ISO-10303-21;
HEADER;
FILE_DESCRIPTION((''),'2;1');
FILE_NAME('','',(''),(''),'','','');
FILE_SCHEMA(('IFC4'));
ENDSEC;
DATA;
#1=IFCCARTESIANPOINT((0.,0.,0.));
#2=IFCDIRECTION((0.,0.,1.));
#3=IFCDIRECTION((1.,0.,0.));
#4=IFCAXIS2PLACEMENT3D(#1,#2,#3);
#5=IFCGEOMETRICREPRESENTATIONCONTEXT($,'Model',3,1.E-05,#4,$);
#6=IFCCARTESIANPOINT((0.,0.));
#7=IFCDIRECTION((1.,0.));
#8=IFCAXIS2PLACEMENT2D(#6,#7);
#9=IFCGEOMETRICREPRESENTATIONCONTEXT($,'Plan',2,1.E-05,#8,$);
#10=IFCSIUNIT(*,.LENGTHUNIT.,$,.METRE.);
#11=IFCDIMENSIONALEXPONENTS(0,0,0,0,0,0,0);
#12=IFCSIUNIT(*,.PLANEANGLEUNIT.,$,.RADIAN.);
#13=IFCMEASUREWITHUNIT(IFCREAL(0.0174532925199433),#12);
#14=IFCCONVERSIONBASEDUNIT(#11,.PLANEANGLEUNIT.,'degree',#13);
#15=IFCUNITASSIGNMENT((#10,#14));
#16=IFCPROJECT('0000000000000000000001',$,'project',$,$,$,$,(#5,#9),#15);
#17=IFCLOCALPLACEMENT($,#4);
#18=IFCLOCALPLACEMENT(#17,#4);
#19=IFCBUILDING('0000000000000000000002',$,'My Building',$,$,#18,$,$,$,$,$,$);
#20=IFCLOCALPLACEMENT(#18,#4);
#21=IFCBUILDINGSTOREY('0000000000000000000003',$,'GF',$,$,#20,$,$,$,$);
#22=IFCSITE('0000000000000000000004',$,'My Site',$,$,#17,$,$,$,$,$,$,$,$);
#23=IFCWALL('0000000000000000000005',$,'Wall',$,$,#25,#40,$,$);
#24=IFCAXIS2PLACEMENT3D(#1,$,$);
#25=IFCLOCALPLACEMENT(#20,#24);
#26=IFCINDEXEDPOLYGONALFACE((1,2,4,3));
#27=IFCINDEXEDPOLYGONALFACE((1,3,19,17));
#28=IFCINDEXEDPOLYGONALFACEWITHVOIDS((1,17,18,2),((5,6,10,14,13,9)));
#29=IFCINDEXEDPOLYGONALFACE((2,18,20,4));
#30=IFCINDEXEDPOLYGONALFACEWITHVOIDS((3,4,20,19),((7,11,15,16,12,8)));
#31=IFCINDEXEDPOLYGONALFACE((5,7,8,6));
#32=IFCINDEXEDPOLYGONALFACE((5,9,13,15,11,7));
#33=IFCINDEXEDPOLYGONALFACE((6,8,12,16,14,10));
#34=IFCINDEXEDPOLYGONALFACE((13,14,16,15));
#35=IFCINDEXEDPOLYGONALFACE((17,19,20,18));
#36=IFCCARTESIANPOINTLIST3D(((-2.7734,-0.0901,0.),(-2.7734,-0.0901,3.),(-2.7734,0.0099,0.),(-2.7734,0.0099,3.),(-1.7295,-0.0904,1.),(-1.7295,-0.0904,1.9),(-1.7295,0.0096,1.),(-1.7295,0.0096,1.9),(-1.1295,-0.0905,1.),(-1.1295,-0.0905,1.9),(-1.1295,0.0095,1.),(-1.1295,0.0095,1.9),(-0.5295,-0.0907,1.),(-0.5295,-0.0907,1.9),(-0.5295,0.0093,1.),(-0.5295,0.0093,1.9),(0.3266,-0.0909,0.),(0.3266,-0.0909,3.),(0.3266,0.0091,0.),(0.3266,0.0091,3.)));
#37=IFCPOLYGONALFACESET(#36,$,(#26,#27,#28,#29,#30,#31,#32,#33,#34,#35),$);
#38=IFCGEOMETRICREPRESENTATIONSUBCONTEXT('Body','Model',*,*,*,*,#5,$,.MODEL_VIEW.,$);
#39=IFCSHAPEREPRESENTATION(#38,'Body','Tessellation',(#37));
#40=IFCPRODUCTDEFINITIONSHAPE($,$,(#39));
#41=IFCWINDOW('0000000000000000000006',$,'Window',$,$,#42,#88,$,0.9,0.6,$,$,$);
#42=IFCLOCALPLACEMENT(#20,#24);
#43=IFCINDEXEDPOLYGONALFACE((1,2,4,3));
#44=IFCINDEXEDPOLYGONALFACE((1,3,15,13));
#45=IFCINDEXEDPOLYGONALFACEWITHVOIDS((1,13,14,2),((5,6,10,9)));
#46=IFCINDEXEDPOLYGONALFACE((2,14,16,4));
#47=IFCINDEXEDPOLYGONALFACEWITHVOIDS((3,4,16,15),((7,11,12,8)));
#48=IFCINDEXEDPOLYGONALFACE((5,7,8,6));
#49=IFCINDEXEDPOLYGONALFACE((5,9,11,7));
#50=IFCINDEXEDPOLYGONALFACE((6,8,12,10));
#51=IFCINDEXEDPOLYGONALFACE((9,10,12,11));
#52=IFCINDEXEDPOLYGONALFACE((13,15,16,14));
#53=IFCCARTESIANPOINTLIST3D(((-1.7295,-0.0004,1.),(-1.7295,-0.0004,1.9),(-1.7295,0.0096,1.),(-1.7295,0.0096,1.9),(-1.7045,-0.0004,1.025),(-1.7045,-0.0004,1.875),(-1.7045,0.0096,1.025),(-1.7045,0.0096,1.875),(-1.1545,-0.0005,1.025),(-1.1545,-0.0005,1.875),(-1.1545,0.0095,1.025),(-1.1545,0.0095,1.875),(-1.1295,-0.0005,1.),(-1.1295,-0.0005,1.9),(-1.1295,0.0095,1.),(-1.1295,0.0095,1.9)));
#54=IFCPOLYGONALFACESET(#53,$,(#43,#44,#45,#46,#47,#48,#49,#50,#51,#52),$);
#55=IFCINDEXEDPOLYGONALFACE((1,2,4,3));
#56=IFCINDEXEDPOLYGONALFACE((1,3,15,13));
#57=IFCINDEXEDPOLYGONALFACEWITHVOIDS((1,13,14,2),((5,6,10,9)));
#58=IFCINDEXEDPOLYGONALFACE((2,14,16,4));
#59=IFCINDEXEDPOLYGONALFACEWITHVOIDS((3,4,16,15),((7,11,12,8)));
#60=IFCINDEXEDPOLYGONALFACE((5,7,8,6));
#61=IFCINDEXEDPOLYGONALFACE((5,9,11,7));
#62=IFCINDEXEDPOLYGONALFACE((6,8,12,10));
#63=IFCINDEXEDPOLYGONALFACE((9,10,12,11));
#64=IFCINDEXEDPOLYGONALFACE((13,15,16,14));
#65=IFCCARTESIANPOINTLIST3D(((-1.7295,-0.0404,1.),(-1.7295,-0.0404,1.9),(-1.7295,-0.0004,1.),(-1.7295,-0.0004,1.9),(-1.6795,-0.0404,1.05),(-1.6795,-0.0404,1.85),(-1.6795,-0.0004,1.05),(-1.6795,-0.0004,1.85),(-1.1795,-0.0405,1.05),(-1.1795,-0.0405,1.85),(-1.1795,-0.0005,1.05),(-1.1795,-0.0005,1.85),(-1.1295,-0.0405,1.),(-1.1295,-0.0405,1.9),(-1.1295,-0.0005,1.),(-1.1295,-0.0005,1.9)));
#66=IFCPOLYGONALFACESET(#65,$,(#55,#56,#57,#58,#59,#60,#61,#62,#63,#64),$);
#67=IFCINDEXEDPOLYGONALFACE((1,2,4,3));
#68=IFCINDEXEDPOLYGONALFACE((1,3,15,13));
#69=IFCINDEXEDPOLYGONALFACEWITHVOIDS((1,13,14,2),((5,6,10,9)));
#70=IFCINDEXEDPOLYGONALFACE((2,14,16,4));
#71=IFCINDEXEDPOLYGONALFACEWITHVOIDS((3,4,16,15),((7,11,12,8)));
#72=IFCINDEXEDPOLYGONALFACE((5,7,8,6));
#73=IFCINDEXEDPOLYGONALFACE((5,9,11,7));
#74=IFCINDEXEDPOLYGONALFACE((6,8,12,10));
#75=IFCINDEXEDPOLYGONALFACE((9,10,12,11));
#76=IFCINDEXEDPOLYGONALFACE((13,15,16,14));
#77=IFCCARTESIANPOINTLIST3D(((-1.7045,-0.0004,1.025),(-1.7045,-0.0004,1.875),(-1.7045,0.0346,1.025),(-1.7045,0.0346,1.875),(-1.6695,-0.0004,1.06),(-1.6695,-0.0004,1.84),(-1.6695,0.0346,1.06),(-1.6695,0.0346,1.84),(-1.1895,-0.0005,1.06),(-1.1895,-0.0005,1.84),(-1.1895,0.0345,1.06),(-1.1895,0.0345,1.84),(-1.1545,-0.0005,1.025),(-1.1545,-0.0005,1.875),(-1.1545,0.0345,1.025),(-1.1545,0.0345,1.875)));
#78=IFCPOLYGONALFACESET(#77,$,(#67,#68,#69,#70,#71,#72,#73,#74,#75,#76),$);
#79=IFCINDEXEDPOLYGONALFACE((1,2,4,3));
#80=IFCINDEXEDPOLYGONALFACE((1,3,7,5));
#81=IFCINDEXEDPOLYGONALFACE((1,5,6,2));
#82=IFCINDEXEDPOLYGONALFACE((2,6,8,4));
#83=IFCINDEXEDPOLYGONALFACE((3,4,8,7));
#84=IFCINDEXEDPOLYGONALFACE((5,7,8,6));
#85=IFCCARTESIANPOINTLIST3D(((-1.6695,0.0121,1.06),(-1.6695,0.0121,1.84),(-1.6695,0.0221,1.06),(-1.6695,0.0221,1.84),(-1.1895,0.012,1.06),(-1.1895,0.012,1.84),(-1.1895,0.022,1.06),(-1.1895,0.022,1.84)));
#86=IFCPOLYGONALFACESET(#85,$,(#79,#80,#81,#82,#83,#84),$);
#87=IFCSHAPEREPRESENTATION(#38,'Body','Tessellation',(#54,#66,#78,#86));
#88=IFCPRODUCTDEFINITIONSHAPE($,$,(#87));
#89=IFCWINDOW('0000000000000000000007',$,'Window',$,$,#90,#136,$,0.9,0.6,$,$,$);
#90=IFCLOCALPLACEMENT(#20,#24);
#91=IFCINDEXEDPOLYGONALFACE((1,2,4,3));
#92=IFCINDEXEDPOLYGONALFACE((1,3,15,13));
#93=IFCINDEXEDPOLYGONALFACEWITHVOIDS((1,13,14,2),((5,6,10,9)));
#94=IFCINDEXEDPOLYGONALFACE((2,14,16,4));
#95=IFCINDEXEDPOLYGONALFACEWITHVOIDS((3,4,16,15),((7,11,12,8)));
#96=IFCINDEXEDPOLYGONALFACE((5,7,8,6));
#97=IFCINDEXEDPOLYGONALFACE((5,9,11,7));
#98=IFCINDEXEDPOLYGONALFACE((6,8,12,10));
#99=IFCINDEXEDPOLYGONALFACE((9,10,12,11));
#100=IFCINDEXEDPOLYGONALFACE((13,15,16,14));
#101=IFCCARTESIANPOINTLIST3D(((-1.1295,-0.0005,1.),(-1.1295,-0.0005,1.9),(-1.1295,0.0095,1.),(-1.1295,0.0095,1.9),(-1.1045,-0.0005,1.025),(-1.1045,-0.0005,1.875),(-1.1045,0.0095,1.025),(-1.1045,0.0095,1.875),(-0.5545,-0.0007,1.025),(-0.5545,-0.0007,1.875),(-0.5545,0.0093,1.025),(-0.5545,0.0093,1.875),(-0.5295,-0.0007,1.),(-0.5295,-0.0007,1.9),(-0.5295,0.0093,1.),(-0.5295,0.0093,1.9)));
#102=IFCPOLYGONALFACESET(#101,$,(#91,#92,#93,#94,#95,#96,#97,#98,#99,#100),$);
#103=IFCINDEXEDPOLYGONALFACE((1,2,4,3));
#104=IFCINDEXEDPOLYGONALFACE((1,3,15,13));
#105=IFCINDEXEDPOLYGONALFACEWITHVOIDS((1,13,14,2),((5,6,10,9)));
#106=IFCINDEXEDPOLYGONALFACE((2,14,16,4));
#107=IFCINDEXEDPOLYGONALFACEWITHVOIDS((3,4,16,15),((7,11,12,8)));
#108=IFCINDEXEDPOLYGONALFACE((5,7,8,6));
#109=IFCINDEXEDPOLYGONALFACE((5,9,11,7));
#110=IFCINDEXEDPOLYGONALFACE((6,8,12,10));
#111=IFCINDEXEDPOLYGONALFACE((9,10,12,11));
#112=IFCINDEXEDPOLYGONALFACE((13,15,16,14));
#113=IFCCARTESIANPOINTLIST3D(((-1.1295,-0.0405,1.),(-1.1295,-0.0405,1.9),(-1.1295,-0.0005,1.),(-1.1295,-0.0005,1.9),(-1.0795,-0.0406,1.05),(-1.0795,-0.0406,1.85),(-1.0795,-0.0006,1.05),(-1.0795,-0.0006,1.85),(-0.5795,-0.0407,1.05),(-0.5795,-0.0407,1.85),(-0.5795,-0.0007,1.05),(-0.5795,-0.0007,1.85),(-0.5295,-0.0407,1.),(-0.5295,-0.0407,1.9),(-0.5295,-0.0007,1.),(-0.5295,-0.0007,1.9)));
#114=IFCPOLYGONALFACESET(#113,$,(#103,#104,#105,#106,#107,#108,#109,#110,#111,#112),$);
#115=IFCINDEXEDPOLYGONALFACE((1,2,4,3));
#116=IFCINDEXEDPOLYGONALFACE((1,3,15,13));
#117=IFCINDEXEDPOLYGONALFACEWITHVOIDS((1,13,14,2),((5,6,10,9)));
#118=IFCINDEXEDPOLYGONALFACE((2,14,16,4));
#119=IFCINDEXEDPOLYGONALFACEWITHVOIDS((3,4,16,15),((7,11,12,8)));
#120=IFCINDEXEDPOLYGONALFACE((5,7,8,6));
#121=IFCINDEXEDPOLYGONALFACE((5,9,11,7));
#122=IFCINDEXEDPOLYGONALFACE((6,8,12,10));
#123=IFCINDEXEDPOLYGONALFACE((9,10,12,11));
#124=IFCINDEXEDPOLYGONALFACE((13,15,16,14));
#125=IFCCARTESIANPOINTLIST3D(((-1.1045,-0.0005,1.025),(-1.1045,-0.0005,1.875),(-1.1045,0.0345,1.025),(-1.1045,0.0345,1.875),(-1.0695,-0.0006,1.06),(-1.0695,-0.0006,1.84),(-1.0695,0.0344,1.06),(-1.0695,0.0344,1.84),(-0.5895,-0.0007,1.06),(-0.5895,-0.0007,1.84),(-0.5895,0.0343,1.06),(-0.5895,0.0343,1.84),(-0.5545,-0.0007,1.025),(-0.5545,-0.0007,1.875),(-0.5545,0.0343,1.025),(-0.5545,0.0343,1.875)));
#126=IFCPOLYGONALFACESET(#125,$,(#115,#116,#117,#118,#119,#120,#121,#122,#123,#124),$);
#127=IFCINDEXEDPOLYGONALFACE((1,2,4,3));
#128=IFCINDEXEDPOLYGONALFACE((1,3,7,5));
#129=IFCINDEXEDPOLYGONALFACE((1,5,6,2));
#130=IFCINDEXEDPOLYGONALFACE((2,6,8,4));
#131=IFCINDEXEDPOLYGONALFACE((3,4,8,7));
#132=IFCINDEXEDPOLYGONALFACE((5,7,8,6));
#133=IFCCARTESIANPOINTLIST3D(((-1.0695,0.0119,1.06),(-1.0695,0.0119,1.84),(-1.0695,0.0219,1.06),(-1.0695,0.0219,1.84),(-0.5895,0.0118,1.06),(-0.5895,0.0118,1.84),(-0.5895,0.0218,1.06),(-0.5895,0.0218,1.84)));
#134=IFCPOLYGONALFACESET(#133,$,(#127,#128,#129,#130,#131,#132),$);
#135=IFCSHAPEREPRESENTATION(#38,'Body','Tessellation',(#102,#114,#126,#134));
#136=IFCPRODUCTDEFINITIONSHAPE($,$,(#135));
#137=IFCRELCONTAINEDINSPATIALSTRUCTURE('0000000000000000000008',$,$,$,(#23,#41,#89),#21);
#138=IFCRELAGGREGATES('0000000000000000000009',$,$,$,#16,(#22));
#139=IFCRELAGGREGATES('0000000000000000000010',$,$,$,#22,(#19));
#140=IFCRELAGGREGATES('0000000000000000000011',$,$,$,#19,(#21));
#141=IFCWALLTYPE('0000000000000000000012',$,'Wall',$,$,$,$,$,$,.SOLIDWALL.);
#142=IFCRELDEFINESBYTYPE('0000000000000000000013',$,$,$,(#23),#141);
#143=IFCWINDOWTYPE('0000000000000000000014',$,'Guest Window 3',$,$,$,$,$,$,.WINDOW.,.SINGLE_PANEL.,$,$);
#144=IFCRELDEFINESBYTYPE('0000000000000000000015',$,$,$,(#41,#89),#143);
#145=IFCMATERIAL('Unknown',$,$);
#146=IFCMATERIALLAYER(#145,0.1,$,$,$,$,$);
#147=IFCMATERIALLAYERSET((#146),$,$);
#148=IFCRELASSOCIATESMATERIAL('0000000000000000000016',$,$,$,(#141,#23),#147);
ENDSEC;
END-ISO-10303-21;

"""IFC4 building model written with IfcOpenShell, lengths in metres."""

from ifc_helpers import new_model, entity, si_unit, converted_unit, frame, origin_with_axes, origin_2d_with_axis, place, context, subcontext, project, spatial, line, indexed_curve, outline, extrude, shape, source, transform, mapped, material, layer, layer_set, layer_usage, type_object, type_shapes, element, fill, save


model = new_model("IFC4")

# Units and contexts
model_context = context("Model", 3, precision=1e-05, world=origin_with_axes())
plan_context = context("Plan", 2, precision=1e-05, world=origin_2d_with_axis())
body_context_1 = subcontext(model_context, "Body", "Model", "MODEL_VIEW")
body_context_2 = subcontext(plan_context, "Body", "Plan", "PLAN_VIEW")
ifc_project = project(units=[si_unit("LENGTHUNIT", "METRE"), converted_unit("PLANEANGLEUNIT", "degree", entity("IfcReal", 0.0174532925199433), si_unit("PLANEANGLEUNIT", "RADIAN"), dimensions=[0, 0, 0, 0, 0, 0, 0])], contexts=[model_context, plan_context])

# Site, building, storey
site_placement = place(None, origin_with_axes())
site = spatial("IfcSite", under=ifc_project, at=site_placement, Name="My Site")
building_placement = place(site_placement, origin_with_axes())
building = spatial("IfcBuilding", under=site, at=building_placement, Name="My Building")
storey_placement = place(building_placement, origin_with_axes())
storey = spatial("IfcBuildingStorey", under=building, at=storey_placement, Name="GF")

# Shared definitions
ifc_material = material(Name="Unknown")

# Shared definitions
ifc_layer_1 = layer(ifc_material, 0.1)
ifc_layer_set_1 = layer_set([ifc_layer_1])
wall_type = type_object("IfcWallType", Name="Wall", PredefinedType="SOLIDWALL", material=ifc_layer_set_1)

# Wall, openings, windows
ifc_layer_usage_1 = layer_usage(ifc_layer_set_1, "AXIS2", "POSITIVE", 0.0)
wall_1_placement = place(storey_placement, frame((-2.7734, -0.0901, 0.0), z_axis=(0.0, 0.0, 1.0), x_axis=(1.0, -0.000264, 0.0)))
wall_1 = element("IfcWall", 1, at=wall_1_placement, inside=storey, type_object=wall_type, material=ifc_layer_usage_1, Name="Wall", context=body_context_1, shape_type="SweptSolid", body=[
    extrude(outline(indexed_curve([(0.0, 0.0), (0.0, 0.1), (3.1, 0.1), (3.1, 0.0)], segments=[line(1, 2, 3, 4, 1)])), origin_with_axes(), (0.0, 0.0, 1.0), 3.0),
])
shared_shape_1 = source(origin_with_axes(), body_context_1, "Body", "SweptSolid", [
    extrude(outline(indexed_curve([(0.0, 0.0), (0.6, 0.0), (0.6, 0.9), (0.0, 0.9)], segments=[line(1, 2, 3, 4, 1)])), frame((0.0, -0.6, 0.0), z_axis=(0.0, -1.0, 0.0), x_axis=(1.0, 0.0, 0.0)), (0.0, 0.0, -1.0), 1.2),
])
opening_1_placement = place(wall_1_placement, frame((1.0439, 0.0, 1.0), z_axis=(0.0, 0.0, 1.0), x_axis=(1.0, 0.0, 0.0)))
opening_1 = element("IfcOpeningElement", 2, at=opening_1_placement, cuts=wall_1, PredefinedType="OPENING", context=body_context_1, shape_type="MappedRepresentation", body=[
    mapped(shared_shape_1, transform((0.0, 0.0, 0.0), x_axis=(1.0, 0.0, 0.0), y_axis=(0.0, 1.0, 0.0), z_axis=(0.0, 0.0, 1.0), scale=1.0)),
])
opening_2_placement = place(wall_1_placement, frame((1.6439, 0.0, 1.0), z_axis=(0.0, 0.0, 1.0), x_axis=(1.0, 0.0, 0.0)))
opening_2 = element("IfcOpeningElement", 3, at=opening_2_placement, cuts=wall_1, PredefinedType="OPENING", context=body_context_1, shape_type="MappedRepresentation", body=[
    mapped(shared_shape_1, transform((0.0, 0.0, 0.0), x_axis=(1.0, 0.0, 0.0), y_axis=(0.0, 1.0, 0.0), z_axis=(0.0, 0.0, 1.0), scale=1.0)),
])
window_type_1 = type_object("IfcWindowType", Name="Guest Window 3", PartitioningType="SINGLE_PANEL", PredefinedType="WINDOW")
shared_shape_2 = source(origin_with_axes(), body_context_1, "Body", "SweptSolid", [
    extrude(outline(indexed_curve([(0.0, 0.0), (0.6, 0.0), (0.6, 0.9), (0.0, 0.9)], segments=[line(1, 2, 3, 4, 1)]), holes=[indexed_curve([(0.025, 0.025), (0.575, 0.025), (0.575, 0.875), (0.025, 0.875)], segments=[line(1, 2, 3, 4, 1)])]), frame((0.0, 0.09, 0.0), z_axis=(0.0, -1.0, 0.0), x_axis=(1.0, 0.0, 0.0)), (0.0, 0.0, -1.0), 0.01),
    extrude(outline(indexed_curve([(0.0, 0.0), (0.6, 0.0), (0.6, 0.9), (0.0, 0.9)], segments=[line(1, 2, 3, 4, 1)]), holes=[indexed_curve([(0.05, 0.05), (0.55, 0.05), (0.55, 0.85), (0.05, 0.85)], segments=[line(1, 2, 3, 4, 1)])]), frame((0.0, 0.05, 0.0), z_axis=(0.0, -1.0, 0.0), x_axis=(1.0, 0.0, 0.0)), (0.0, 0.0, -1.0), 0.04),
    extrude(outline(indexed_curve([(0.0, 0.0), (0.55, 0.0), (0.55, 0.85), (0.0, 0.85)], segments=[line(1, 2, 3, 4, 1)]), holes=[indexed_curve([(0.035, 0.035), (0.515, 0.035), (0.515, 0.815), (0.035, 0.815)], segments=[line(1, 2, 3, 4, 1)])]), frame((0.025, 0.09, 0.025), z_axis=(0.0, -1.0, 0.0), x_axis=(1.0, 0.0, 0.0)), (0.0, 0.0, -1.0), 0.035),
    extrude(outline(indexed_curve([(0.035, 0.035), (0.515, 0.035), (0.515, 0.815), (0.035, 0.815)], segments=[line(1, 2, 3, 4, 1)])), frame((0.025, 0.1025, 0.025), z_axis=(0.0, -1.0, 0.0), x_axis=(1.0, 0.0, 0.0)), (0.0, 0.0, -1.0), 0.01),
])
shared_shape_3 = source(origin_with_axes(), body_context_2, "Body", "Curve2D", [
    entity("IfcIndexedPolyCurve", entity("IfcCartesianPointList2D", [[0.05, 0.05], [0.55, 0.05]])),
    entity("IfcIndexedPolyCurve", entity("IfcCartesianPointList2D", [[0.0, 0.1], [0.025, 0.1], [0.025, 0.09], [0.05, 0.09], [0.05, 0.05], [0.0, 0.05]]), [entity("IfcLineIndex", [1, 2, 3, 4, 5, 6, 1])]),
    entity("IfcIndexedPolyCurve", entity("IfcCartesianPointList2D", [[0.6, 0.1], [0.575, 0.1], [0.575, 0.09], [0.55, 0.09], [0.55, 0.05], [0.6, 0.05]]), [entity("IfcLineIndex", [1, 2, 3, 4, 5, 6, 1])]),
    entity("IfcIndexedPolyCurve", entity("IfcCartesianPointList2D", [[0.025, 0.09], [0.06, 0.09], [0.06, 0.125], [0.025, 0.125]]), [entity("IfcLineIndex", [1, 2, 3, 4, 1])]),
    entity("IfcIndexedPolyCurve", entity("IfcCartesianPointList2D", [[0.575, 0.09], [0.54, 0.09], [0.54, 0.125], [0.575, 0.125]]), [entity("IfcLineIndex", [1, 2, 3, 4, 1])]),
    entity("IfcIndexedPolyCurve", entity("IfcCartesianPointList2D", [[0.06, 0.09], [0.54, 0.09]])),
    entity("IfcIndexedPolyCurve", entity("IfcCartesianPointList2D", [[0.06, 0.125], [0.54, 0.125]])),
    entity("IfcIndexedPolyCurve", entity("IfcCartesianPointList2D", [[0.06, 0.1075], [0.54, 0.1075]])),
])
type_shapes(window_type_1, [shared_shape_2, shared_shape_3])
window_1_placement = place(opening_1_placement, frame((0.0, 0.0, 0.0), z_axis=(0.0, 0.0, 1.0), x_axis=(1.0, 0.0, 0.0)))
window_1 = element("IfcWindow", 4, at=window_1_placement, inside=storey, type_object=window_type_1, Name="Window", OverallHeight=0.9, OverallWidth=0.6, shapes=[
    shape(body_context_1, "Body", "MappedRepresentation", [mapped(shared_shape_2, transform((0.0, 0.0, 0.0), x_axis=(1.0, 0.0, 0.0), y_axis=(0.0, 1.0, 0.0), z_axis=(0.0, 0.0, 1.0), scale=1.0))]),
    shape(body_context_2, "Body", "MappedRepresentation", [mapped(shared_shape_3, transform((0.0, 0.0, 0.0), x_axis=(1.0, 0.0, 0.0), y_axis=(0.0, 1.0, 0.0), z_axis=(0.0, 0.0, 1.0), scale=1.0))]),
])
fill(opening_1, window_1)
window_2_placement = place(opening_2_placement, frame((0.0, 0.0, 0.0), z_axis=(0.0, 0.0, 1.0), x_axis=(1.0, 0.0, 0.0)))
window_2 = element("IfcWindow", 5, at=window_2_placement, inside=storey, type_object=window_type_1, Name="Window", OverallHeight=0.9, OverallWidth=0.6, shapes=[
    shape(body_context_1, "Body", "MappedRepresentation", [mapped(shared_shape_2, transform((0.0, 0.0, 0.0), x_axis=(1.0, 0.0, 0.0), y_axis=(0.0, 1.0, 0.0), z_axis=(0.0, 0.0, 1.0), scale=1.0))]),
    shape(body_context_2, "Body", "MappedRepresentation", [mapped(shared_shape_3, transform((0.0, 0.0, 0.0), x_axis=(1.0, 0.0, 0.0), y_axis=(0.0, 1.0, 0.0), z_axis=(0.0, 0.0, 1.0), scale=1.0))]),
])
fill(opening_2, window_2)

save(model, "model.ifc")
